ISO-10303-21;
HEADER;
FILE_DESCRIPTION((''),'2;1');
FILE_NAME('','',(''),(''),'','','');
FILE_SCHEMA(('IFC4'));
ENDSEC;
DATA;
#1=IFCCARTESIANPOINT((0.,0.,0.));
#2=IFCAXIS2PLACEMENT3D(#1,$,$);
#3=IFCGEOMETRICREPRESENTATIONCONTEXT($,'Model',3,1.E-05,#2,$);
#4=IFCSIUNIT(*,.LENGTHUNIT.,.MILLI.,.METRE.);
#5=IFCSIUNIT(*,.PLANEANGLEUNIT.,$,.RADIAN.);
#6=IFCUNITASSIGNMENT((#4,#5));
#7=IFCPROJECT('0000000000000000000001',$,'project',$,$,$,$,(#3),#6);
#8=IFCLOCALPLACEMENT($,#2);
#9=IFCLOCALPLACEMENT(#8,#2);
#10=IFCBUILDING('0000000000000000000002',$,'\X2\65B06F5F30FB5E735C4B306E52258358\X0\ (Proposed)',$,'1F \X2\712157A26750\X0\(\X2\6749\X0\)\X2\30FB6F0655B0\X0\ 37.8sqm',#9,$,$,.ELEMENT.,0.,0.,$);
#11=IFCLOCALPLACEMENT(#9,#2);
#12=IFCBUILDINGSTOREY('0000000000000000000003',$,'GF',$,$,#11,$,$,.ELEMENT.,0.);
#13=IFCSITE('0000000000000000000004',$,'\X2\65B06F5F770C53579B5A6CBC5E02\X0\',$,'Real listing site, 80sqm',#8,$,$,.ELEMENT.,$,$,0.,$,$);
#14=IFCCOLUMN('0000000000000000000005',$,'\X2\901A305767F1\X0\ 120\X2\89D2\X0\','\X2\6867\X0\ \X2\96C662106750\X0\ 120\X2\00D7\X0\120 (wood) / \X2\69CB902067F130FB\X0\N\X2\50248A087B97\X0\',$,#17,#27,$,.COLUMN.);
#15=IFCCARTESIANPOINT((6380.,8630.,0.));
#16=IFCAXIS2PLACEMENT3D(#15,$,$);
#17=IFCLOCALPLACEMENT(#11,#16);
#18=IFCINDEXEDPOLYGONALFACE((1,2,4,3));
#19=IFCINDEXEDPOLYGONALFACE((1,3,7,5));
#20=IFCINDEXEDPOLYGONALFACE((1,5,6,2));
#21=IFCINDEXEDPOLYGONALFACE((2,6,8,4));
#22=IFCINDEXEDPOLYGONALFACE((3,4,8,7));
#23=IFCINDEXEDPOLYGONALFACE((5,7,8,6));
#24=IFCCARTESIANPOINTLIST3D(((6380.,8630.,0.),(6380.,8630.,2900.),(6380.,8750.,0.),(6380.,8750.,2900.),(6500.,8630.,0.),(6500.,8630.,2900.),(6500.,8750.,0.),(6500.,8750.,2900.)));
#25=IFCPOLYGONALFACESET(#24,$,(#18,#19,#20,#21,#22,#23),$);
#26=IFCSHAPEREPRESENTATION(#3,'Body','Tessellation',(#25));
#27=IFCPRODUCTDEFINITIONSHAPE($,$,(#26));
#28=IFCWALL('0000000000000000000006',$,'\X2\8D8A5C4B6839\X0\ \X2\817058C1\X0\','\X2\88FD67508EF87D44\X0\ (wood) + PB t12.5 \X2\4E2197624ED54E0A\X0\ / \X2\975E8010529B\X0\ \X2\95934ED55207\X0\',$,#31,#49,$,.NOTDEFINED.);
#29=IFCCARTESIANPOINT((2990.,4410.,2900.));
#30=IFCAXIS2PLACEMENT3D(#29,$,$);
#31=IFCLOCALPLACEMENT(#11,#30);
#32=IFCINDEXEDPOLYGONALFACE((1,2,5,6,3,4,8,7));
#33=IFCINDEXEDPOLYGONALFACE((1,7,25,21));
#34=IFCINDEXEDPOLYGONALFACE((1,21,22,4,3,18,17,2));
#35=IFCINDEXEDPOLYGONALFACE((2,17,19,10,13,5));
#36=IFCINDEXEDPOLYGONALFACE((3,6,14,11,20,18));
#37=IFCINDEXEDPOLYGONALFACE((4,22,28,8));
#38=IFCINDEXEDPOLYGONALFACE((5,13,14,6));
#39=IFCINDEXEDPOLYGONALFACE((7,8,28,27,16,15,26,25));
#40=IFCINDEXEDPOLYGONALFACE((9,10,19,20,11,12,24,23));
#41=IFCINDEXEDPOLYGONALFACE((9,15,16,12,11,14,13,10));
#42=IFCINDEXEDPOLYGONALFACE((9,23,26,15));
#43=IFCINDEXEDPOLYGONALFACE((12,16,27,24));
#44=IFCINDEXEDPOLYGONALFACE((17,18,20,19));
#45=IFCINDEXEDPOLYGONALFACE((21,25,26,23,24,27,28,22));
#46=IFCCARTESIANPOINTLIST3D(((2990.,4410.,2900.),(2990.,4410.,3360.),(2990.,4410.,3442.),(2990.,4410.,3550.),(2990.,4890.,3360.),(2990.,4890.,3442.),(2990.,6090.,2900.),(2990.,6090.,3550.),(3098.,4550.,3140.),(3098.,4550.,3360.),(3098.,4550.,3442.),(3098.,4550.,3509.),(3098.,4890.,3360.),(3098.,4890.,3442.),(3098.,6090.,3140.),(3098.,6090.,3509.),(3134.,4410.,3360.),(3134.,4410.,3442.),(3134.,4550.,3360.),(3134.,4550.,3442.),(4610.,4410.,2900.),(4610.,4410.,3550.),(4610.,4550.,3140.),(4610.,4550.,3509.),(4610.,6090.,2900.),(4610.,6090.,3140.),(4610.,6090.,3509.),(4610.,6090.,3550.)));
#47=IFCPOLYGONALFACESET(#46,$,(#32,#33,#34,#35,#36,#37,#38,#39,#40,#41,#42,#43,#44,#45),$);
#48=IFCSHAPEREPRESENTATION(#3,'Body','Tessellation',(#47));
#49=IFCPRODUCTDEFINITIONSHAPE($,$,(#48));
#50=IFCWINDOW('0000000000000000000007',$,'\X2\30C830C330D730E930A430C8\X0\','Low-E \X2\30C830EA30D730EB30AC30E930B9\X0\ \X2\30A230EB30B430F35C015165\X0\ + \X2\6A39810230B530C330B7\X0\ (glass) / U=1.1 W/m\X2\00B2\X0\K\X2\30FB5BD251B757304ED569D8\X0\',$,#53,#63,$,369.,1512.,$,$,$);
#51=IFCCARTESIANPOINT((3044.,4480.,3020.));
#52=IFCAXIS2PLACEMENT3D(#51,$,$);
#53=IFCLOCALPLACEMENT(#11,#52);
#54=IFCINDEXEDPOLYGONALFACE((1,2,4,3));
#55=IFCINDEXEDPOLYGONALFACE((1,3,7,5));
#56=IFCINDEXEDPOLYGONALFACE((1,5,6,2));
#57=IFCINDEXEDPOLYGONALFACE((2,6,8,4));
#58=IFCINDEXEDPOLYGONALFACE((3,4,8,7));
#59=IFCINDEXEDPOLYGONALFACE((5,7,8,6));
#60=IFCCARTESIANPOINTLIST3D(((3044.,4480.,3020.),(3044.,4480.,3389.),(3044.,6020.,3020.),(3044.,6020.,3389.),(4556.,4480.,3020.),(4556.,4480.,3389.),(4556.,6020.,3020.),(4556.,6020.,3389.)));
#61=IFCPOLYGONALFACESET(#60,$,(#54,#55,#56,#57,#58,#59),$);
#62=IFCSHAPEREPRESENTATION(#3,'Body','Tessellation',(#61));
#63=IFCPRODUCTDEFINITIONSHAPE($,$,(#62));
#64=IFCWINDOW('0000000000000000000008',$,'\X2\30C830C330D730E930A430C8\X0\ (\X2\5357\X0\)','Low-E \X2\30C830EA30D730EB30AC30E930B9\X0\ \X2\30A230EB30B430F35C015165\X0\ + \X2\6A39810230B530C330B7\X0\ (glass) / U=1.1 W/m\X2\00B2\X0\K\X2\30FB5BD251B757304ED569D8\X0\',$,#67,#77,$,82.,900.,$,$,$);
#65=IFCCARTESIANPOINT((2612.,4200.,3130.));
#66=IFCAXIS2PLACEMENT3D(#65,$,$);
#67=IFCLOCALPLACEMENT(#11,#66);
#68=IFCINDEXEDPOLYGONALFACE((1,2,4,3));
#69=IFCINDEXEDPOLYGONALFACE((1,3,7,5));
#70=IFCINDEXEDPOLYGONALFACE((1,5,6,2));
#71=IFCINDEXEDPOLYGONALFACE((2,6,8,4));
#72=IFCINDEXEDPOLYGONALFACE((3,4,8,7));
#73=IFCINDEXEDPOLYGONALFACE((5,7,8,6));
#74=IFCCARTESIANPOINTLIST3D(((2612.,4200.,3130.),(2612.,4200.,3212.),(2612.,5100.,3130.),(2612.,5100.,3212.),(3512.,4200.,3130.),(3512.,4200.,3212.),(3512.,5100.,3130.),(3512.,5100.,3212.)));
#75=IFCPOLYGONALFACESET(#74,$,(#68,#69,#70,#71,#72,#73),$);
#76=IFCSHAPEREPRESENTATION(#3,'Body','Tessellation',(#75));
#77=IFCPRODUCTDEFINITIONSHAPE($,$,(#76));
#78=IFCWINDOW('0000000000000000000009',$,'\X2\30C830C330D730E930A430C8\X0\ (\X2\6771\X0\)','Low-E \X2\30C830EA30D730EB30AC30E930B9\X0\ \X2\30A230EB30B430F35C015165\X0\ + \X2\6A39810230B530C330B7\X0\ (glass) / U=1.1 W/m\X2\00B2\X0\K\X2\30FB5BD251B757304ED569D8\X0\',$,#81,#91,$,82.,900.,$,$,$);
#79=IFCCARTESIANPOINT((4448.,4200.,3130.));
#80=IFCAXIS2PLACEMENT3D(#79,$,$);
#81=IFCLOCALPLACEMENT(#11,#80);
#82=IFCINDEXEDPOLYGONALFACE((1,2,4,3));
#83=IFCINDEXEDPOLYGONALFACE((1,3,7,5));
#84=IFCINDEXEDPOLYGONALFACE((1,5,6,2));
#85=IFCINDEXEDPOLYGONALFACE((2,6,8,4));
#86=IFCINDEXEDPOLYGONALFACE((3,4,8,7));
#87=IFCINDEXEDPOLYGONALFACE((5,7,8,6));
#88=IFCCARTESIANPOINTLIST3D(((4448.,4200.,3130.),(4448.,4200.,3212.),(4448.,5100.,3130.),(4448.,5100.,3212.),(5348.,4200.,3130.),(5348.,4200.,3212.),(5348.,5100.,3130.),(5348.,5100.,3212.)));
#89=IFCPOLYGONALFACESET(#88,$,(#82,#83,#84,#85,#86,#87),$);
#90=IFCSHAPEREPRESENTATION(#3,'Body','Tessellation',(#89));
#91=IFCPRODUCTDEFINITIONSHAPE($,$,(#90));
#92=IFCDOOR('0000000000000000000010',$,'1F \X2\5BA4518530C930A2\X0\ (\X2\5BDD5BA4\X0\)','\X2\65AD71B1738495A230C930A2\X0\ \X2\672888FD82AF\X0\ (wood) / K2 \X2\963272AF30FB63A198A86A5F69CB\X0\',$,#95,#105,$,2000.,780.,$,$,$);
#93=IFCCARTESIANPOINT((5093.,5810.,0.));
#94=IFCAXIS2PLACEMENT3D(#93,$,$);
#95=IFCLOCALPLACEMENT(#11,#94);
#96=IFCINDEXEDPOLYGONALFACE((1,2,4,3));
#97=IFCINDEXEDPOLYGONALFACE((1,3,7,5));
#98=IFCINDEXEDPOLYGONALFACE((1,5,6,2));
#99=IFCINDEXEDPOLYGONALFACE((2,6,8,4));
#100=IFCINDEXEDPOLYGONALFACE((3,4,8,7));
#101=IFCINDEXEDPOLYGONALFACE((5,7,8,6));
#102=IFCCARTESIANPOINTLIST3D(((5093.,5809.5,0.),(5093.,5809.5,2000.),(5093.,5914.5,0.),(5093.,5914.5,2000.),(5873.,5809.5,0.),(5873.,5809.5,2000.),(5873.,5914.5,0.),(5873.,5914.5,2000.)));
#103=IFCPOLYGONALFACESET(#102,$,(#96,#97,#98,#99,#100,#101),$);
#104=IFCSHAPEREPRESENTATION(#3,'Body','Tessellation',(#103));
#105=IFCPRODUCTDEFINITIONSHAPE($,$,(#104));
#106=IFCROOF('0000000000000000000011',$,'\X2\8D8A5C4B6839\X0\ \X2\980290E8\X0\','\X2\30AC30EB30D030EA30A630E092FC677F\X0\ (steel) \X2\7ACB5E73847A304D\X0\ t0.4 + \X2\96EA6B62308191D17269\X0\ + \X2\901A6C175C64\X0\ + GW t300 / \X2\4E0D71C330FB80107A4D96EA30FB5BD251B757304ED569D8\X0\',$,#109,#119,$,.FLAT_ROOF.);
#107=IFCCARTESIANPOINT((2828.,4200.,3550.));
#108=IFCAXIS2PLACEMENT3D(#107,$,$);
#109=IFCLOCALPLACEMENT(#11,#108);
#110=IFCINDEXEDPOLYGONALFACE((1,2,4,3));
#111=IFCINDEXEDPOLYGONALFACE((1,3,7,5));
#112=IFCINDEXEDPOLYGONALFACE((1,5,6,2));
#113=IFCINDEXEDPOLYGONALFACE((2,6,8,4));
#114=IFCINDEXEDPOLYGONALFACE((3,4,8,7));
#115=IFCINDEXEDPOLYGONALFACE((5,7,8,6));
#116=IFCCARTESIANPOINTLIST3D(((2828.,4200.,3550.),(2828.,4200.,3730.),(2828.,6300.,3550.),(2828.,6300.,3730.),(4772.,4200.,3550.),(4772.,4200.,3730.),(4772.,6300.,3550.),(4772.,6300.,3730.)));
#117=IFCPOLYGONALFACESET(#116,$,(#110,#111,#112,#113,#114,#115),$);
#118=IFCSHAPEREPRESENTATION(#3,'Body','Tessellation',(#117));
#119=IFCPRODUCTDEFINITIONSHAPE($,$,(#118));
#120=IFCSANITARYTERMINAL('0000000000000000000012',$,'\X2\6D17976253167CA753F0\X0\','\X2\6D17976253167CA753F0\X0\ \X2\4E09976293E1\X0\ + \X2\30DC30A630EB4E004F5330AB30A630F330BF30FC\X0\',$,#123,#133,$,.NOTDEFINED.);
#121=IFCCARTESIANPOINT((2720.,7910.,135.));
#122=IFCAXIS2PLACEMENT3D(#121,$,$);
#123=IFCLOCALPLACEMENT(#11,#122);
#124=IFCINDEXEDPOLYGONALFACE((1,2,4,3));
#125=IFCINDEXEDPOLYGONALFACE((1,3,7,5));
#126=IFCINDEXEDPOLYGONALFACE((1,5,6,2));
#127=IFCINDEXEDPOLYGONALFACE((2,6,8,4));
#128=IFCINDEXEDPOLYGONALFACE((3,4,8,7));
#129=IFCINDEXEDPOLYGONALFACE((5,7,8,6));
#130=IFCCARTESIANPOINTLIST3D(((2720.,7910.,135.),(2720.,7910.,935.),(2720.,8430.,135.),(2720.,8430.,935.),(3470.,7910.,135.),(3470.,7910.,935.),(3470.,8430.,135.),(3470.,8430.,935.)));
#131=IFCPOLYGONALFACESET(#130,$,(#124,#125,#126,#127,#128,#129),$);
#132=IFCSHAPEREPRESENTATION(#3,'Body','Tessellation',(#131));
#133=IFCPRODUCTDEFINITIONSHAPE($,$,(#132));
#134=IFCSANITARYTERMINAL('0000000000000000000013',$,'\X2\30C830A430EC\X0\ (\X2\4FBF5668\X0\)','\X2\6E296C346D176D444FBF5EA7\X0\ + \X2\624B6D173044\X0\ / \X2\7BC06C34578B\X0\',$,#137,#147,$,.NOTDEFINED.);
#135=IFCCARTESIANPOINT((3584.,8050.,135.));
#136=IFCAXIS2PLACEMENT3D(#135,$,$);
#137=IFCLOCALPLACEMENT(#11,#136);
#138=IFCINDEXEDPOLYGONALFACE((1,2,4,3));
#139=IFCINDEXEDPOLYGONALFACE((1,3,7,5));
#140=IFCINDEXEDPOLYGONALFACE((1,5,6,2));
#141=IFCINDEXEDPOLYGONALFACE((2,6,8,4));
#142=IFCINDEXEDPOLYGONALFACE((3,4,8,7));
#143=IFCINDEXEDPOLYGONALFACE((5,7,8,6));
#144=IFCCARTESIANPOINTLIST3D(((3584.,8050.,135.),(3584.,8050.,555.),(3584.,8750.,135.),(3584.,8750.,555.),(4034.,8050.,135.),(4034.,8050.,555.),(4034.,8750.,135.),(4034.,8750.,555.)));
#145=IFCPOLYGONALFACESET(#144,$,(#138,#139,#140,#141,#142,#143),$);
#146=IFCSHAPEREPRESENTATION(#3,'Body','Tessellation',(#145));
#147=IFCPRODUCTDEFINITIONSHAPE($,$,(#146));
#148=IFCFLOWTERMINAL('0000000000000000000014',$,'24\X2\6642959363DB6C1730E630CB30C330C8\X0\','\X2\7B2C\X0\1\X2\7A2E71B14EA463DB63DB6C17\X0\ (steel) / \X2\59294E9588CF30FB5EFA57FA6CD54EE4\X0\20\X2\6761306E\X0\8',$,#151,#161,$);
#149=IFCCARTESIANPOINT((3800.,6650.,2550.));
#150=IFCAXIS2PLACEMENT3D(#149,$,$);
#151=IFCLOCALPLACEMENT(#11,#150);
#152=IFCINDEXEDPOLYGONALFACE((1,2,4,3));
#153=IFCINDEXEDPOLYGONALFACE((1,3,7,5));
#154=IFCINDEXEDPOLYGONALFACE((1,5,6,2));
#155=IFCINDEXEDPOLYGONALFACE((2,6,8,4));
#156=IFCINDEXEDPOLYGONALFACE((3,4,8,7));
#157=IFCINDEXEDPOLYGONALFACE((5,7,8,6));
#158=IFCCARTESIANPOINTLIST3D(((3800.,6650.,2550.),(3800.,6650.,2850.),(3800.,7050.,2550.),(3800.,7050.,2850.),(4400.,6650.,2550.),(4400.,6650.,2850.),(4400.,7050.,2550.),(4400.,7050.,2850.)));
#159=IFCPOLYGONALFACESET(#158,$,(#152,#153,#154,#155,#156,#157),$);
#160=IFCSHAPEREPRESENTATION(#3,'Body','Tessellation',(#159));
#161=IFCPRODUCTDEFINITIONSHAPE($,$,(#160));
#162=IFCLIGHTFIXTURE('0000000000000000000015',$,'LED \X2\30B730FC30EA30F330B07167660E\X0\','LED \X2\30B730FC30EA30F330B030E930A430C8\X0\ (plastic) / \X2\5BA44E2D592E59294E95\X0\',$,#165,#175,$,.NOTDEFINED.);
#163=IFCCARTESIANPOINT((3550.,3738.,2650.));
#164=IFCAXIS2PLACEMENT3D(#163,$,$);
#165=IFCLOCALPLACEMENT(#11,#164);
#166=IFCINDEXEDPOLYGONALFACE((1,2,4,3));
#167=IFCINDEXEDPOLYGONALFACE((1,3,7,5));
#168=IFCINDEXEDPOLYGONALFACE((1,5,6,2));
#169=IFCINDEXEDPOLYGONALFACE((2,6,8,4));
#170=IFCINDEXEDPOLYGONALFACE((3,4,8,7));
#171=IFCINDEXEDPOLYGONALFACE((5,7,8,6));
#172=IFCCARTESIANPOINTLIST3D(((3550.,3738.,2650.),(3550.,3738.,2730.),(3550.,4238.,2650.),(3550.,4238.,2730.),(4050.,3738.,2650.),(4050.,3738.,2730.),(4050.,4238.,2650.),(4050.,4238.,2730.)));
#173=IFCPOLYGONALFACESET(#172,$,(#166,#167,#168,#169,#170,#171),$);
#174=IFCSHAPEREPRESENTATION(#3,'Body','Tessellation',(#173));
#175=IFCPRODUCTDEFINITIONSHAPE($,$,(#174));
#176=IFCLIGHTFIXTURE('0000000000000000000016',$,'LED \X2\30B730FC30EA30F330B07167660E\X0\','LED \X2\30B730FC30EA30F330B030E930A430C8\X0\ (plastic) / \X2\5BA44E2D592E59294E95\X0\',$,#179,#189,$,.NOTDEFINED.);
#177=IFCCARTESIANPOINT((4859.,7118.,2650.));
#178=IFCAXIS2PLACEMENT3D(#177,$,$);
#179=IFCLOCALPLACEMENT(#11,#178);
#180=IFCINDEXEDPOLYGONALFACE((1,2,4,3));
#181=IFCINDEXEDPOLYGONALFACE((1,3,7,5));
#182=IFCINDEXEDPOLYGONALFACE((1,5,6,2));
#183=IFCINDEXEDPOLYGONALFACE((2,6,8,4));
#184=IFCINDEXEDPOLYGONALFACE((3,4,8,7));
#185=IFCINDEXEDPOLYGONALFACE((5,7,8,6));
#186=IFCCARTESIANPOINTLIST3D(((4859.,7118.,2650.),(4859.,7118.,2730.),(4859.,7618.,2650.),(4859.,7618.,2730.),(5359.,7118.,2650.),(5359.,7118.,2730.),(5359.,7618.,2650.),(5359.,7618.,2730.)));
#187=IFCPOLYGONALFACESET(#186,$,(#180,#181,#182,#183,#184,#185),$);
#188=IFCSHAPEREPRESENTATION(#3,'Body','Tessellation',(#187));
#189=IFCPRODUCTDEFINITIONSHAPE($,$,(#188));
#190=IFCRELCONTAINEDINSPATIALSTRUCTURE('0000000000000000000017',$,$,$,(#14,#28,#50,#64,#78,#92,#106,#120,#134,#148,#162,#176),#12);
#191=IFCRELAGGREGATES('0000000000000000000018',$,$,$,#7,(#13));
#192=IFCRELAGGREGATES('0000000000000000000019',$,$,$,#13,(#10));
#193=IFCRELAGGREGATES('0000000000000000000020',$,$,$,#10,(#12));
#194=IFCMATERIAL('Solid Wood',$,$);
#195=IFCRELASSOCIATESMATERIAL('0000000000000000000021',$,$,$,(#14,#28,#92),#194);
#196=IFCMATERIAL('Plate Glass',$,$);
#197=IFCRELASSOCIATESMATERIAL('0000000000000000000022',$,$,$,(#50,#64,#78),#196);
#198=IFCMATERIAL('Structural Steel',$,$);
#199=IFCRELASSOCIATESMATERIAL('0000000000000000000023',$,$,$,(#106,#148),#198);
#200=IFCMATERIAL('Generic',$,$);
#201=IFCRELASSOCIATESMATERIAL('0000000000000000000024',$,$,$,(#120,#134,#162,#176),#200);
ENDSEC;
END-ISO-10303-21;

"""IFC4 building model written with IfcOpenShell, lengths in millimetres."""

from ifc_helpers import new_model, si_unit, frame, frame_2d, origin, place, context, project, spatial, rectangle, extrude, material, element, fill, save


model = new_model("IFC4")

# Units and contexts
model_context = context("Model", 3, precision=1e-05, world=origin())
ifc_project = project(units=[si_unit("LENGTHUNIT", "METRE", prefix="MILLI"), si_unit("PLANEANGLEUNIT", "RADIAN")], contexts=[model_context])

# Site, building, storey
site_placement = place(None, origin())
site = spatial("IfcSite", under=ifc_project, at=site_placement, Name="新潟県南魚沼市", ObjectType="Real listing site, 80sqm", CompositionType="ELEMENT", RefElevation=0.0)
building_placement = place(site_placement, origin())
building = spatial("IfcBuilding", under=site, at=building_placement, Name="新潟・平屋の別荘 (Proposed)", ObjectType="1F 無垢材(杉)・漆喰 37.8sqm", CompositionType="ELEMENT", ElevationOfRefHeight=0.0, ElevationOfTerrain=0.0)
storey_placement = place(building_placement, origin())
storey = spatial("IfcBuildingStorey", under=building, at=storey_placement, Name="GF", CompositionType="ELEMENT", Elevation=0.0)

# Column
ifc_material_1 = material(Name="Solid Wood")
column_1_placement = place(storey_placement, frame((6380.0, 8630.0, 0.0)))
element("IfcColumn", 1, at=column_1_placement, inside=storey, material=ifc_material_1, Name="通し柱 120角", Description="桧 集成材 120×120 (wood) / 構造柱・N値計算", PredefinedType="COLUMN", context=model_context, shape_type="SweptSolid", body=[
    extrude(rectangle(XDim=120.0, YDim=120.0, at=frame_2d((60.0, 60.0))), frame((6380.0, 8630.0, 0.0)), (0.0, 0.0, 1.0), 2900.0),
])

# Wall, openings, windows
wall_1_placement = place(storey_placement, frame((2990.0, 4410.0, 2900.0)))
wall_1 = element("IfcWall", 2, at=wall_1_placement, inside=storey, material=ifc_material_1, Name="越屋根 腰壁", Description="製材軸組 (wood) + PB t12.5 両面仕上 / 非耐力 間仕切", PredefinedType="NOTDEFINED", context=model_context, shape_type="SweptSolid", body=[
    extrude(rectangle(XDim=1620.0, YDim=1680.0, at=frame_2d((810.0, 840.0))), frame((2990.0, 4410.0, 2900.0)), (0.0, 0.0, 1.0), 650.0),
])
opening_1_placement = place(storey_placement, frame((3044.0, 4480.0, 3020.0)))
opening_1 = element("IfcOpeningElement", 3, at=opening_1_placement, cuts=wall_1, PredefinedType="NOTDEFINED", context=model_context, shape_type="SweptSolid", body=[
    extrude(rectangle(XDim=1512.0, YDim=1540.0, at=frame_2d((756.0, 770.0))), frame((3044.0, 4480.0, 3020.0)), (0.0, 0.0, 1.0), 369.0),
])
opening_2_placement = place(storey_placement, frame((2612.0, 4200.0, 3130.0)))
opening_2 = element("IfcOpeningElement", 4, at=opening_2_placement, cuts=wall_1, PredefinedType="NOTDEFINED", context=model_context, shape_type="SweptSolid", body=[
    extrude(rectangle(XDim=900.0, YDim=900.0, at=frame_2d((450.0, 450.0))), frame((2612.0, 4200.0, 3130.0)), (0.0, 0.0, 1.0), 82.0),
])
opening_3_placement = place(storey_placement, frame((4448.0, 4200.0, 3130.0)))
opening_3 = element("IfcOpeningElement", 5, at=opening_3_placement, cuts=wall_1, PredefinedType="NOTDEFINED", context=model_context, shape_type="SweptSolid", body=[
    extrude(rectangle(XDim=900.0, YDim=900.0, at=frame_2d((450.0, 450.0))), frame((4448.0, 4200.0, 3130.0)), (0.0, 0.0, 1.0), 82.0),
])
ifc_material_2 = material(Name="Plate Glass")
window_1_placement = place(storey_placement, frame((3044.0, 4480.0, 3020.0)))
window_1 = element("IfcWindow", 6, at=window_1_placement, inside=storey, material=ifc_material_2, Name="トップライト", Description="Low-E トリプルガラス アルゴン封入 + 樹脂サッシ (glass) / U=1.1 W/m²K・寒冷地仕様", OverallHeight=369.0, OverallWidth=1512.0, context=model_context, shape_type="SweptSolid", body=[
    extrude(rectangle(XDim=1512.0, YDim=1540.0, at=frame_2d((756.0, 770.0))), frame((3044.0, 4480.0, 3020.0)), (0.0, 0.0, 1.0), 369.0),
])
fill(opening_1, window_1)
window_2_placement = place(storey_placement, frame((2612.0, 4200.0, 3130.0)))
window_2 = element("IfcWindow", 7, at=window_2_placement, inside=storey, material=ifc_material_2, Name="トップライト (南)", Description="Low-E トリプルガラス アルゴン封入 + 樹脂サッシ (glass) / U=1.1 W/m²K・寒冷地仕様", OverallHeight=82.0, OverallWidth=900.0, context=model_context, shape_type="SweptSolid", body=[
    extrude(rectangle(XDim=900.0, YDim=900.0, at=frame_2d((450.0, 450.0))), frame((2612.0, 4200.0, 3130.0)), (0.0, 0.0, 1.0), 82.0),
])
fill(opening_2, window_2)
window_3_placement = place(storey_placement, frame((4448.0, 4200.0, 3130.0)))
window_3 = element("IfcWindow", 8, at=window_3_placement, inside=storey, material=ifc_material_2, Name="トップライト (東)", Description="Low-E トリプルガラス アルゴン封入 + 樹脂サッシ (glass) / U=1.1 W/m²K・寒冷地仕様", OverallHeight=82.0, OverallWidth=900.0, context=model_context, shape_type="SweptSolid", body=[
    extrude(rectangle(XDim=900.0, YDim=900.0, at=frame_2d((450.0, 450.0))), frame((4448.0, 4200.0, 3130.0)), (0.0, 0.0, 1.0), 82.0),
])
fill(opening_3, window_3)

# Door
door_placement = place(storey_placement, frame((5093.0, 5810.0, 0.0)))
element("IfcDoor", 9, at=door_placement, inside=storey, material=ifc_material_1, Name="1F 室内ドア (寝室)", Description="断熱玄関ドア 木製芯 (wood) / K2 防犯・採風機構", OverallHeight=2000.0, OverallWidth=780.0, context=model_context, shape_type="SweptSolid", body=[
    extrude(rectangle(XDim=780.0, YDim=105.0, at=frame_2d((390.0, 52.0))), frame((5093.0, 5810.0, 0.0)), (0.0, 0.0, 1.0), 2000.0),
])

# Roof
ifc_material_3 = material(Name="Structural Steel")
roof_placement = place(storey_placement, frame((2828.0, 4200.0, 3550.0)))
element("IfcRoof", 10, at=roof_placement, inside=storey, material=ifc_material_3, Name="越屋根 頂部", Description="ガルバリウム鋼板 (steel) 立平葺き t0.4 + 雪止め金物 + 通気層 + GW t300 / 不燃・耐積雪・寒冷地仕様", PredefinedType="FLAT_ROOF", context=model_context, shape_type="SweptSolid", body=[
    extrude(rectangle(XDim=1944.0, YDim=2100.0, at=frame_2d((972.0, 1050.0))), frame((2828.0, 4200.0, 3550.0)), (0.0, 0.0, 1.0), 180.0),
])

# Sanitary terminals
ifc_material_4 = material(Name="Generic")
sanitary_terminal_1_placement = place(storey_placement, frame((2720.0, 7910.0, 135.0)))
element("IfcSanitaryTerminal", 11, at=sanitary_terminal_1_placement, inside=storey, material=ifc_material_4, Name="洗面化粧台", Description="洗面化粧台 三面鏡 + ボウル一体カウンター", PredefinedType="NOTDEFINED", context=model_context, shape_type="SweptSolid", body=[
    extrude(rectangle(XDim=750.0, YDim=520.0, at=frame_2d((375.0, 260.0))), frame((2720.0, 7910.0, 135.0)), (0.0, 0.0, 1.0), 800.0),
])
sanitary_terminal_2_placement = place(storey_placement, frame((3584.0, 8050.0, 135.0)))
element("IfcSanitaryTerminal", 12, at=sanitary_terminal_2_placement, inside=storey, material=ifc_material_4, Name="トイレ (便器)", Description="温水洗浄便座 + 手洗い / 節水型", PredefinedType="NOTDEFINED", context=model_context, shape_type="SweptSolid", body=[
    extrude(rectangle(XDim=450.0, YDim=700.0, at=frame_2d((225.0, 350.0))), frame((3584.0, 8050.0, 135.0)), (0.0, 0.0, 1.0), 420.0),
])

# Flow terminal
flow_terminal_placement = place(storey_placement, frame((3800.0, 6650.0, 2550.0)))
element("IfcFlowTerminal", 13, at=flow_terminal_placement, inside=storey, material=ifc_material_3, Name="24時間換気ユニット", Description="第1種熱交換換気 (steel) / 天井裏・建基法令20条の8", context=model_context, shape_type="SweptSolid", body=[
    extrude(rectangle(XDim=600.0, YDim=400.0, at=frame_2d((300.0, 200.0))), frame((3800.0, 6650.0, 2550.0)), (0.0, 0.0, 1.0), 300.0),
])

# Light fixtures
light_fixture_1_placement = place(storey_placement, frame((3550.0, 3738.0, 2650.0)))
element("IfcLightFixture", 14, at=light_fixture_1_placement, inside=storey, material=ifc_material_4, Name="LED シーリング照明", Description="LED シーリングライト (plastic) / 室中央天井", PredefinedType="NOTDEFINED", context=model_context, shape_type="SweptSolid", body=[
    extrude(rectangle(XDim=500.0, YDim=500.0, at=frame_2d((250.0, 250.0))), frame((3550.0, 3738.0, 2650.0)), (0.0, 0.0, 1.0), 80.0),
])
light_fixture_2_placement = place(storey_placement, frame((4859.0, 7118.0, 2650.0)))
element("IfcLightFixture", 15, at=light_fixture_2_placement, inside=storey, material=ifc_material_4, Name="LED シーリング照明", Description="LED シーリングライト (plastic) / 室中央天井", PredefinedType="NOTDEFINED", context=model_context, shape_type="SweptSolid", body=[
    extrude(rectangle(XDim=500.0, YDim=500.0, at=frame_2d((250.0, 250.0))), frame((4859.0, 7118.0, 2650.0)), (0.0, 0.0, 1.0), 80.0),
])

save(model, "model.ifc")
